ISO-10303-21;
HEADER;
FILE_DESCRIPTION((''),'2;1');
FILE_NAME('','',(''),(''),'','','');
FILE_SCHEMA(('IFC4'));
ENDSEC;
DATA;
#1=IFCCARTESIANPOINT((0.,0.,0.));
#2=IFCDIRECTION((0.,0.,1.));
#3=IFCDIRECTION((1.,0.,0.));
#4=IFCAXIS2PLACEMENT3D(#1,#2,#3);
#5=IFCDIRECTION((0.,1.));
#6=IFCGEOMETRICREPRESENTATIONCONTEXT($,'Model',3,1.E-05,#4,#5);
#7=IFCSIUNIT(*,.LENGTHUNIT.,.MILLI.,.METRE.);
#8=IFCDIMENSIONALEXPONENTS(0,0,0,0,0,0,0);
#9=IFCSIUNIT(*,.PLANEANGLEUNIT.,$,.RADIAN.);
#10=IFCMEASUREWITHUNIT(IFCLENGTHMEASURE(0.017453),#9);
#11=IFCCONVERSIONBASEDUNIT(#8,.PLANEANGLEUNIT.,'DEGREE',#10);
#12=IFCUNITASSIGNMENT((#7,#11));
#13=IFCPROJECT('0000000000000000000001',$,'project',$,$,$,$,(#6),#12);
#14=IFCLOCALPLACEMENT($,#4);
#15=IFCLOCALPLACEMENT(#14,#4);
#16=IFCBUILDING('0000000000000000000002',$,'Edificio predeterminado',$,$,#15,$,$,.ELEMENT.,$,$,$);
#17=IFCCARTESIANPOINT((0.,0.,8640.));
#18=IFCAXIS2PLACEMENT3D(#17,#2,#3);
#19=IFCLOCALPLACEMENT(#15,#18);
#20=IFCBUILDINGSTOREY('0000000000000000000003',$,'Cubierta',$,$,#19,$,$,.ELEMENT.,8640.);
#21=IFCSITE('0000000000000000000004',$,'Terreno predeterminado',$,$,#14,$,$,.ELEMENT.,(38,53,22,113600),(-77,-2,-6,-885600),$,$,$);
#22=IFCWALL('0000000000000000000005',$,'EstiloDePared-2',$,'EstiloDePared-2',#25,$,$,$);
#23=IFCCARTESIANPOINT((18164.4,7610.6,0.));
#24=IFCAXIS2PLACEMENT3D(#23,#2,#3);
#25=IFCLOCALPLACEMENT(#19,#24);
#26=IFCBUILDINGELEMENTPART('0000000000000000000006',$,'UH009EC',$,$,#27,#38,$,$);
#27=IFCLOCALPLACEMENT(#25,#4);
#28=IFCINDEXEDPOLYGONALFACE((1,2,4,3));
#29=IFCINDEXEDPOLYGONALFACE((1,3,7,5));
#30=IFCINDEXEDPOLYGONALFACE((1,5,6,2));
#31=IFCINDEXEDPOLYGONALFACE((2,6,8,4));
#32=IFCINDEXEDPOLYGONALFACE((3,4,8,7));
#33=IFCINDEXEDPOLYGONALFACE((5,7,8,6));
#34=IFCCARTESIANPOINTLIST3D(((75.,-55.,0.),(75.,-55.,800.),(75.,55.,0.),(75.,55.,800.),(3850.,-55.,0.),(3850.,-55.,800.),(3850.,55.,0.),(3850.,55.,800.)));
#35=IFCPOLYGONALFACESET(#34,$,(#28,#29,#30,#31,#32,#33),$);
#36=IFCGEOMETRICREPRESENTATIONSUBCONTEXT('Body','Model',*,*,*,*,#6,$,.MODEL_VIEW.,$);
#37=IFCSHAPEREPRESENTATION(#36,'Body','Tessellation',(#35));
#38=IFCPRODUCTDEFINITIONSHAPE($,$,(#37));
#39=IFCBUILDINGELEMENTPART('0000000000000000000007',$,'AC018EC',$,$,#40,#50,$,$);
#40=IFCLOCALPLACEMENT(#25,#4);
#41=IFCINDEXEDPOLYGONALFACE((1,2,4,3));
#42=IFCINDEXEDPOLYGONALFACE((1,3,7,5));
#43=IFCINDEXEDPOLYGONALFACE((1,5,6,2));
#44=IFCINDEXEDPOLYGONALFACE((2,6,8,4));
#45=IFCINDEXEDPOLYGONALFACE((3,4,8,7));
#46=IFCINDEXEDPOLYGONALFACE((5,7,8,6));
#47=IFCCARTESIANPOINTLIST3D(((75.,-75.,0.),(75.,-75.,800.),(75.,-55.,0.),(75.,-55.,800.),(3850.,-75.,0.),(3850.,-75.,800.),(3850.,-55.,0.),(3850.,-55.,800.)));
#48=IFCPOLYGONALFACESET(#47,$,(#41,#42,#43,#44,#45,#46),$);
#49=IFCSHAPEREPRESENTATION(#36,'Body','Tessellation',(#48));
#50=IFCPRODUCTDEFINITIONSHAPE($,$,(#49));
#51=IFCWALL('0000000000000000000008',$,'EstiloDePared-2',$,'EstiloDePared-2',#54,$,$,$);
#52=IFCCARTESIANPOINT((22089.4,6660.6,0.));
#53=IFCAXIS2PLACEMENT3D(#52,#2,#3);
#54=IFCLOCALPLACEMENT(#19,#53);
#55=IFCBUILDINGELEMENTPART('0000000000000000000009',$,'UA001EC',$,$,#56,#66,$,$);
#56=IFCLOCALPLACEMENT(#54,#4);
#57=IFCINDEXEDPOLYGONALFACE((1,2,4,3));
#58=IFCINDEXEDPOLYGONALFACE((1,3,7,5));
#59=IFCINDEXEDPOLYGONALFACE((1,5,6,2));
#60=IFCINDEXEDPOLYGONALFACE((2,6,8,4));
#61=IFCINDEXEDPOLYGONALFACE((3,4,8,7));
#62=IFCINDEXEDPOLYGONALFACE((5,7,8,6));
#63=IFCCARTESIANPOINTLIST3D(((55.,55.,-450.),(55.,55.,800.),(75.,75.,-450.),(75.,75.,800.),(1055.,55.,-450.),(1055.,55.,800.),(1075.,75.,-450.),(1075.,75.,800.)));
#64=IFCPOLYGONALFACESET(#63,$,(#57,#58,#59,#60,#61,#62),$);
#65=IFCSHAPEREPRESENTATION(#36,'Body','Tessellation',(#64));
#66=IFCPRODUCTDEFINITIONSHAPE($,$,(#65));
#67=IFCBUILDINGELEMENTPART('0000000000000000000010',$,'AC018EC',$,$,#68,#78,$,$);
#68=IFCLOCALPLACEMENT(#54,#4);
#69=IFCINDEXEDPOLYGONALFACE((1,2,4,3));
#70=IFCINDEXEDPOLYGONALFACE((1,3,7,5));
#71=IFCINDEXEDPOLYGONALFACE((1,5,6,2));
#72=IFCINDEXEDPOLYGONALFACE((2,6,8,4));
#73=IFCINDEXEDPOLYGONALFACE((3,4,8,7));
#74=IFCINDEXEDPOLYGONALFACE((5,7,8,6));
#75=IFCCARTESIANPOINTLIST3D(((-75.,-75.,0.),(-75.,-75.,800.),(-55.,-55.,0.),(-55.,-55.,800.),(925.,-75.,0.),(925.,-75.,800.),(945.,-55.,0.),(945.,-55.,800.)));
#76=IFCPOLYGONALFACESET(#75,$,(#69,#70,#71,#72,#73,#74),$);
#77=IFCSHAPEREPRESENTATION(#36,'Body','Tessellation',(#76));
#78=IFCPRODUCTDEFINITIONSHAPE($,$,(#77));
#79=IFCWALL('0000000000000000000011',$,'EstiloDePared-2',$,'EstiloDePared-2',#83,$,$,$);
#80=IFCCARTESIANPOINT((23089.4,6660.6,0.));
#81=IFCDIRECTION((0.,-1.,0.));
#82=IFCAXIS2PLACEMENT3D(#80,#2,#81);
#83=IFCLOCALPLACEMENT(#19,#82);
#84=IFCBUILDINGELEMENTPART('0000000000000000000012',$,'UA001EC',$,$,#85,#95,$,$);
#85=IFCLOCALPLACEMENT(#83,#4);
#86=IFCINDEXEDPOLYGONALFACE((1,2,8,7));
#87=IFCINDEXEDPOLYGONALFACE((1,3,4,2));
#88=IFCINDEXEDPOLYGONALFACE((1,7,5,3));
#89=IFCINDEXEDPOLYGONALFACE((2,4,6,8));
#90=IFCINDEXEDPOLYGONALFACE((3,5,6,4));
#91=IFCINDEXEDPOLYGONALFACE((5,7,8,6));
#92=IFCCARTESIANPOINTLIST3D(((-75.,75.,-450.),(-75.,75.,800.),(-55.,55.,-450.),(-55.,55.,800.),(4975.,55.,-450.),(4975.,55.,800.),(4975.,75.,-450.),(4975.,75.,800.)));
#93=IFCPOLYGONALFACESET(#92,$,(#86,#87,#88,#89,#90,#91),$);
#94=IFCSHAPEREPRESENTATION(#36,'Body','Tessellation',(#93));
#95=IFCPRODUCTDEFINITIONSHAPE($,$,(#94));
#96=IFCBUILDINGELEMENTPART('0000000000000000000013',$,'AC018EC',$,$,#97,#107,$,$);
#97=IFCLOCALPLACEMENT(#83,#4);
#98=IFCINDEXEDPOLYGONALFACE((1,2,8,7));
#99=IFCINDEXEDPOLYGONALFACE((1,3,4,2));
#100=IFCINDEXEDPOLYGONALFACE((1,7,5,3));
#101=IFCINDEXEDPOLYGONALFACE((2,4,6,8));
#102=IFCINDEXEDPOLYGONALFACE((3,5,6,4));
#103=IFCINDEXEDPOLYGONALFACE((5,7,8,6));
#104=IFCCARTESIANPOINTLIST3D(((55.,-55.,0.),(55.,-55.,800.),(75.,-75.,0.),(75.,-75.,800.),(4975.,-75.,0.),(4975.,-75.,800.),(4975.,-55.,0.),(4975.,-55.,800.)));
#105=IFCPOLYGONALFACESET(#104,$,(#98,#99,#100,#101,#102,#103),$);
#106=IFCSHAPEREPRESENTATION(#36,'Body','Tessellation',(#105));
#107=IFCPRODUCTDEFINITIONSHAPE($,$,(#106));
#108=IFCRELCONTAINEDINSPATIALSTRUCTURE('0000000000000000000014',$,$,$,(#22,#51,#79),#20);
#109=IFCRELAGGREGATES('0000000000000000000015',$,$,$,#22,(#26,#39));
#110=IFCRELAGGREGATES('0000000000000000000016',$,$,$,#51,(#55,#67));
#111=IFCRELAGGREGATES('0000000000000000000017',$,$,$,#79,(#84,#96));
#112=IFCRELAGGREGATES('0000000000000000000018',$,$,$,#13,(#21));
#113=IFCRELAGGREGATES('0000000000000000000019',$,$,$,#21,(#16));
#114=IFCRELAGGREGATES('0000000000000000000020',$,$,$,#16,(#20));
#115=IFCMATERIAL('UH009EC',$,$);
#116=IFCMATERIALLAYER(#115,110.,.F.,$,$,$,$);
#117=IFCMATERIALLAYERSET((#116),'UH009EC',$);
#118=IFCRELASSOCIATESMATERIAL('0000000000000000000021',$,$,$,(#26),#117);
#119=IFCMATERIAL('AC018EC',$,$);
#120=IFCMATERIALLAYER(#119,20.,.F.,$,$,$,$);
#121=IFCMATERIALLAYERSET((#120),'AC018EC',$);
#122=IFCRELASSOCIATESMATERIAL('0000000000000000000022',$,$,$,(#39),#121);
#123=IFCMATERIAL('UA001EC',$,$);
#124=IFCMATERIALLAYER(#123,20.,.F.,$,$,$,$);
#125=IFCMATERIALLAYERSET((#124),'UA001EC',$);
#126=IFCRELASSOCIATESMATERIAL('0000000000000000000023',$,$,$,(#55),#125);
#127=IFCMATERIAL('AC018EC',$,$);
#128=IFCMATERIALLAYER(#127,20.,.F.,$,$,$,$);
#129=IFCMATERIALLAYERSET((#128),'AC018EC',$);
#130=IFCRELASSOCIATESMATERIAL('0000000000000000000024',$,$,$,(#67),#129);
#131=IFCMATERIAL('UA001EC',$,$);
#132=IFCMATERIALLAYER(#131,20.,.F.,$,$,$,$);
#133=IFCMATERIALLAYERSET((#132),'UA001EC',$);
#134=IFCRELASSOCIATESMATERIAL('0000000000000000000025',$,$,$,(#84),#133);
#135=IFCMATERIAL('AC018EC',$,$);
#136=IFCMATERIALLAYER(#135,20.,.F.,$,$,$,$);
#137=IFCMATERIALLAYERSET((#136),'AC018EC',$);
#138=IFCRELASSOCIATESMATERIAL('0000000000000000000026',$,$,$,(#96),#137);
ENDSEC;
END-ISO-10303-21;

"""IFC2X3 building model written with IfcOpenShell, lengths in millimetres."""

from ifc_helpers import new_model, entity, si_unit, converted_unit, direction, frame, origin_with_axes, place, context, subcontext, project, spatial, polyline, outline, extrude, material, layer, layer_set, layer_usage, element, aggregate, save


model = new_model("IFC2X3")

# Units and contexts
model_context = context("Model", 3, precision=1e-05, world=origin_with_axes(), true_north=direction((0.0, 1.0)))
body_context = subcontext(model_context, "Body", "Model", "MODEL_VIEW")
ifc_project = project(units=[si_unit("LENGTHUNIT", "METRE", prefix="MILLI"), converted_unit("PLANEANGLEUNIT", "DEGREE", entity("IfcLengthMeasure", 0.017453), si_unit("PLANEANGLEUNIT", "RADIAN"), dimensions=[0, 0, 0, 0, 0, 0, 0])], contexts=[model_context])

# Site, building, storey
site_placement = place(None, origin_with_axes())
site = spatial("IfcSite", under=ifc_project, at=site_placement, Name="Terreno predeterminado", CompositionType="ELEMENT", RefLatitude=(38, 53, 22, 113600), RefLongitude=(-77, -2, -6, -885600))
building_placement = place(site_placement, origin_with_axes())
building = spatial("IfcBuilding", under=site, at=building_placement, Name="Edificio predeterminado", CompositionType="ELEMENT")
storey_placement = place(building_placement, frame((0.0, 0.0, 8640.0), z_axis=(0.0, 0.0, 1.0), x_axis=(1.0, 0.0, 0.0)))
storey = spatial("IfcBuildingStorey", under=building, at=storey_placement, Name="Cubierta", CompositionType="ELEMENT", Elevation=8640.0)

# Walls, building element parts
wall_1_placement = place(storey_placement, frame((18164.4, 7610.6, 0.0), z_axis=(0.0, 0.0, 1.0), x_axis=(1.0, 0.0, 0.0)))
wall_1 = element("IfcWall", 1, at=wall_1_placement, inside=storey, Name="EstiloDePared-2", ObjectType="EstiloDePared-2")
ifc_material_1 = material(Name="UH009EC")
ifc_layer_1 = layer(ifc_material_1, 110.0, ventilated=False)
ifc_layer_set_1 = layer_set([ifc_layer_1], Name="UH009EC")
ifc_layer_usage_1 = layer_usage(ifc_layer_set_1, "AXIS2", "NEGATIVE", -55.0)
building_element_part_1_placement = place(wall_1_placement, origin_with_axes())
building_element_part_1 = element("IfcBuildingElementPart", 2, at=building_element_part_1_placement, material=ifc_layer_usage_1, Name="UH009EC", context=body_context, shape_type="SweptSolid", body=[
    extrude(outline(polyline([(3850.0, 55.0), (3850.0, -55.0), (75.0, -55.0), (75.0, 55.0), (3850.0, 55.0)])), origin_with_axes(), (0.0, 0.0, 1.0), 800.0),
])
ifc_material_2 = material(Name="AC018EC")
ifc_layer_2 = layer(ifc_material_2, 20.0, ventilated=False)
ifc_layer_set_2 = layer_set([ifc_layer_2], Name="AC018EC")
ifc_layer_usage_2 = layer_usage(ifc_layer_set_2, "AXIS2", "NEGATIVE", 55.0)
building_element_part_2_placement = place(wall_1_placement, origin_with_axes())
building_element_part_2 = element("IfcBuildingElementPart", 3, at=building_element_part_2_placement, material=ifc_layer_usage_2, Name="AC018EC", context=body_context, shape_type="SweptSolid", body=[
    extrude(outline(polyline([(3850.0, -55.0), (3850.0, -75.0), (75.0, -75.0), (75.0, -55.0), (3850.0, -55.0)])), origin_with_axes(), (0.0, 0.0, 1.0), 800.0),
])
aggregate(wall_1, [building_element_part_1, building_element_part_2])
wall_2_placement = place(storey_placement, frame((22089.4, 6660.6, 0.0), z_axis=(0.0, 0.0, 1.0), x_axis=(1.0, 0.0, 0.0)))
wall_2 = element("IfcWall", 4, at=wall_2_placement, inside=storey, Name="EstiloDePared-2", ObjectType="EstiloDePared-2")
ifc_material_3 = material(Name="UA001EC")
ifc_layer_3 = layer(ifc_material_3, 20.0, ventilated=False)
ifc_layer_set_3 = layer_set([ifc_layer_3], Name="UA001EC")
ifc_layer_usage_3 = layer_usage(ifc_layer_set_3, "AXIS2", "NEGATIVE", -75.0)
building_element_part_3_placement = place(wall_2_placement, origin_with_axes())
building_element_part_3 = element("IfcBuildingElementPart", 5, at=building_element_part_3_placement, material=ifc_layer_usage_3, Name="UA001EC", context=body_context, shape_type="SweptSolid", body=[
    extrude(outline(polyline([(1075.0, 75.0), (1055.0, 55.0), (55.0, 55.0), (75.0, 75.0), (1075.0, 75.0)])), frame((0.0, 0.0, -450.0), z_axis=(0.0, 0.0, 1.0), x_axis=(1.0, 0.0, 0.0)), (0.0, 0.0, 1.0), 1250.0),
])
ifc_material_4 = material(Name="AC018EC")
ifc_layer_4 = layer(ifc_material_4, 20.0, ventilated=False)
ifc_layer_set_4 = layer_set([ifc_layer_4], Name="AC018EC")
ifc_layer_usage_4 = layer_usage(ifc_layer_set_4, "AXIS2", "NEGATIVE", 55.0)
building_element_part_4_placement = place(wall_2_placement, origin_with_axes())
building_element_part_4 = element("IfcBuildingElementPart", 6, at=building_element_part_4_placement, material=ifc_layer_usage_4, Name="AC018EC", context=body_context, shape_type="SweptSolid", body=[
    extrude(outline(polyline([(945.0, -55.0), (925.0, -75.0), (-75.0, -75.0), (-55.0, -55.0), (945.0, -55.0)])), origin_with_axes(), (0.0, 0.0, 1.0), 800.0),
])
aggregate(wall_2, [building_element_part_3, building_element_part_4])
wall_3_placement = place(storey_placement, frame((23089.4, 6660.6, 0.0), z_axis=(0.0, 0.0, 1.0), x_axis=(0.0, -1.0, 0.0)))
wall_3 = element("IfcWall", 7, at=wall_3_placement, inside=storey, Name="EstiloDePared-2", ObjectType="EstiloDePared-2")
ifc_material_5 = material(Name="UA001EC")
ifc_layer_5 = layer(ifc_material_5, 20.0, ventilated=False)
ifc_layer_set_5 = layer_set([ifc_layer_5], Name="UA001EC")
ifc_layer_usage_5 = layer_usage(ifc_layer_set_5, "AXIS2", "NEGATIVE", -75.0)
building_element_part_5_placement = place(wall_3_placement, origin_with_axes())
building_element_part_5 = element("IfcBuildingElementPart", 8, at=building_element_part_5_placement, material=ifc_layer_usage_5, Name="UA001EC", context=body_context, shape_type="SweptSolid", body=[
    extrude(outline(polyline([(4975.0, 75.0), (4975.0, 55.0), (-55.0, 55.0), (-75.0, 75.0), (4975.0, 75.0)])), frame((0.0, 0.0, -450.0), z_axis=(0.0, 0.0, 1.0), x_axis=(1.0, 0.0, 0.0)), (0.0, 0.0, 1.0), 1250.0),
])
ifc_material_6 = material(Name="AC018EC")
ifc_layer_6 = layer(ifc_material_6, 20.0, ventilated=False)
ifc_layer_set_6 = layer_set([ifc_layer_6], Name="AC018EC")
ifc_layer_usage_6 = layer_usage(ifc_layer_set_6, "AXIS2", "NEGATIVE", 55.0)
building_element_part_6_placement = place(wall_3_placement, origin_with_axes())
building_element_part_6 = element("IfcBuildingElementPart", 9, at=building_element_part_6_placement, material=ifc_layer_usage_6, Name="AC018EC", context=body_context, shape_type="SweptSolid", body=[
    extrude(outline(polyline([(4975.0, -55.0), (4975.0, -75.0), (75.0, -75.0), (55.0, -55.0), (4975.0, -55.0)])), origin_with_axes(), (0.0, 0.0, 1.0), 800.0),
])
aggregate(wall_3, [building_element_part_5, building_element_part_6])

save(model, "model.ifc")
